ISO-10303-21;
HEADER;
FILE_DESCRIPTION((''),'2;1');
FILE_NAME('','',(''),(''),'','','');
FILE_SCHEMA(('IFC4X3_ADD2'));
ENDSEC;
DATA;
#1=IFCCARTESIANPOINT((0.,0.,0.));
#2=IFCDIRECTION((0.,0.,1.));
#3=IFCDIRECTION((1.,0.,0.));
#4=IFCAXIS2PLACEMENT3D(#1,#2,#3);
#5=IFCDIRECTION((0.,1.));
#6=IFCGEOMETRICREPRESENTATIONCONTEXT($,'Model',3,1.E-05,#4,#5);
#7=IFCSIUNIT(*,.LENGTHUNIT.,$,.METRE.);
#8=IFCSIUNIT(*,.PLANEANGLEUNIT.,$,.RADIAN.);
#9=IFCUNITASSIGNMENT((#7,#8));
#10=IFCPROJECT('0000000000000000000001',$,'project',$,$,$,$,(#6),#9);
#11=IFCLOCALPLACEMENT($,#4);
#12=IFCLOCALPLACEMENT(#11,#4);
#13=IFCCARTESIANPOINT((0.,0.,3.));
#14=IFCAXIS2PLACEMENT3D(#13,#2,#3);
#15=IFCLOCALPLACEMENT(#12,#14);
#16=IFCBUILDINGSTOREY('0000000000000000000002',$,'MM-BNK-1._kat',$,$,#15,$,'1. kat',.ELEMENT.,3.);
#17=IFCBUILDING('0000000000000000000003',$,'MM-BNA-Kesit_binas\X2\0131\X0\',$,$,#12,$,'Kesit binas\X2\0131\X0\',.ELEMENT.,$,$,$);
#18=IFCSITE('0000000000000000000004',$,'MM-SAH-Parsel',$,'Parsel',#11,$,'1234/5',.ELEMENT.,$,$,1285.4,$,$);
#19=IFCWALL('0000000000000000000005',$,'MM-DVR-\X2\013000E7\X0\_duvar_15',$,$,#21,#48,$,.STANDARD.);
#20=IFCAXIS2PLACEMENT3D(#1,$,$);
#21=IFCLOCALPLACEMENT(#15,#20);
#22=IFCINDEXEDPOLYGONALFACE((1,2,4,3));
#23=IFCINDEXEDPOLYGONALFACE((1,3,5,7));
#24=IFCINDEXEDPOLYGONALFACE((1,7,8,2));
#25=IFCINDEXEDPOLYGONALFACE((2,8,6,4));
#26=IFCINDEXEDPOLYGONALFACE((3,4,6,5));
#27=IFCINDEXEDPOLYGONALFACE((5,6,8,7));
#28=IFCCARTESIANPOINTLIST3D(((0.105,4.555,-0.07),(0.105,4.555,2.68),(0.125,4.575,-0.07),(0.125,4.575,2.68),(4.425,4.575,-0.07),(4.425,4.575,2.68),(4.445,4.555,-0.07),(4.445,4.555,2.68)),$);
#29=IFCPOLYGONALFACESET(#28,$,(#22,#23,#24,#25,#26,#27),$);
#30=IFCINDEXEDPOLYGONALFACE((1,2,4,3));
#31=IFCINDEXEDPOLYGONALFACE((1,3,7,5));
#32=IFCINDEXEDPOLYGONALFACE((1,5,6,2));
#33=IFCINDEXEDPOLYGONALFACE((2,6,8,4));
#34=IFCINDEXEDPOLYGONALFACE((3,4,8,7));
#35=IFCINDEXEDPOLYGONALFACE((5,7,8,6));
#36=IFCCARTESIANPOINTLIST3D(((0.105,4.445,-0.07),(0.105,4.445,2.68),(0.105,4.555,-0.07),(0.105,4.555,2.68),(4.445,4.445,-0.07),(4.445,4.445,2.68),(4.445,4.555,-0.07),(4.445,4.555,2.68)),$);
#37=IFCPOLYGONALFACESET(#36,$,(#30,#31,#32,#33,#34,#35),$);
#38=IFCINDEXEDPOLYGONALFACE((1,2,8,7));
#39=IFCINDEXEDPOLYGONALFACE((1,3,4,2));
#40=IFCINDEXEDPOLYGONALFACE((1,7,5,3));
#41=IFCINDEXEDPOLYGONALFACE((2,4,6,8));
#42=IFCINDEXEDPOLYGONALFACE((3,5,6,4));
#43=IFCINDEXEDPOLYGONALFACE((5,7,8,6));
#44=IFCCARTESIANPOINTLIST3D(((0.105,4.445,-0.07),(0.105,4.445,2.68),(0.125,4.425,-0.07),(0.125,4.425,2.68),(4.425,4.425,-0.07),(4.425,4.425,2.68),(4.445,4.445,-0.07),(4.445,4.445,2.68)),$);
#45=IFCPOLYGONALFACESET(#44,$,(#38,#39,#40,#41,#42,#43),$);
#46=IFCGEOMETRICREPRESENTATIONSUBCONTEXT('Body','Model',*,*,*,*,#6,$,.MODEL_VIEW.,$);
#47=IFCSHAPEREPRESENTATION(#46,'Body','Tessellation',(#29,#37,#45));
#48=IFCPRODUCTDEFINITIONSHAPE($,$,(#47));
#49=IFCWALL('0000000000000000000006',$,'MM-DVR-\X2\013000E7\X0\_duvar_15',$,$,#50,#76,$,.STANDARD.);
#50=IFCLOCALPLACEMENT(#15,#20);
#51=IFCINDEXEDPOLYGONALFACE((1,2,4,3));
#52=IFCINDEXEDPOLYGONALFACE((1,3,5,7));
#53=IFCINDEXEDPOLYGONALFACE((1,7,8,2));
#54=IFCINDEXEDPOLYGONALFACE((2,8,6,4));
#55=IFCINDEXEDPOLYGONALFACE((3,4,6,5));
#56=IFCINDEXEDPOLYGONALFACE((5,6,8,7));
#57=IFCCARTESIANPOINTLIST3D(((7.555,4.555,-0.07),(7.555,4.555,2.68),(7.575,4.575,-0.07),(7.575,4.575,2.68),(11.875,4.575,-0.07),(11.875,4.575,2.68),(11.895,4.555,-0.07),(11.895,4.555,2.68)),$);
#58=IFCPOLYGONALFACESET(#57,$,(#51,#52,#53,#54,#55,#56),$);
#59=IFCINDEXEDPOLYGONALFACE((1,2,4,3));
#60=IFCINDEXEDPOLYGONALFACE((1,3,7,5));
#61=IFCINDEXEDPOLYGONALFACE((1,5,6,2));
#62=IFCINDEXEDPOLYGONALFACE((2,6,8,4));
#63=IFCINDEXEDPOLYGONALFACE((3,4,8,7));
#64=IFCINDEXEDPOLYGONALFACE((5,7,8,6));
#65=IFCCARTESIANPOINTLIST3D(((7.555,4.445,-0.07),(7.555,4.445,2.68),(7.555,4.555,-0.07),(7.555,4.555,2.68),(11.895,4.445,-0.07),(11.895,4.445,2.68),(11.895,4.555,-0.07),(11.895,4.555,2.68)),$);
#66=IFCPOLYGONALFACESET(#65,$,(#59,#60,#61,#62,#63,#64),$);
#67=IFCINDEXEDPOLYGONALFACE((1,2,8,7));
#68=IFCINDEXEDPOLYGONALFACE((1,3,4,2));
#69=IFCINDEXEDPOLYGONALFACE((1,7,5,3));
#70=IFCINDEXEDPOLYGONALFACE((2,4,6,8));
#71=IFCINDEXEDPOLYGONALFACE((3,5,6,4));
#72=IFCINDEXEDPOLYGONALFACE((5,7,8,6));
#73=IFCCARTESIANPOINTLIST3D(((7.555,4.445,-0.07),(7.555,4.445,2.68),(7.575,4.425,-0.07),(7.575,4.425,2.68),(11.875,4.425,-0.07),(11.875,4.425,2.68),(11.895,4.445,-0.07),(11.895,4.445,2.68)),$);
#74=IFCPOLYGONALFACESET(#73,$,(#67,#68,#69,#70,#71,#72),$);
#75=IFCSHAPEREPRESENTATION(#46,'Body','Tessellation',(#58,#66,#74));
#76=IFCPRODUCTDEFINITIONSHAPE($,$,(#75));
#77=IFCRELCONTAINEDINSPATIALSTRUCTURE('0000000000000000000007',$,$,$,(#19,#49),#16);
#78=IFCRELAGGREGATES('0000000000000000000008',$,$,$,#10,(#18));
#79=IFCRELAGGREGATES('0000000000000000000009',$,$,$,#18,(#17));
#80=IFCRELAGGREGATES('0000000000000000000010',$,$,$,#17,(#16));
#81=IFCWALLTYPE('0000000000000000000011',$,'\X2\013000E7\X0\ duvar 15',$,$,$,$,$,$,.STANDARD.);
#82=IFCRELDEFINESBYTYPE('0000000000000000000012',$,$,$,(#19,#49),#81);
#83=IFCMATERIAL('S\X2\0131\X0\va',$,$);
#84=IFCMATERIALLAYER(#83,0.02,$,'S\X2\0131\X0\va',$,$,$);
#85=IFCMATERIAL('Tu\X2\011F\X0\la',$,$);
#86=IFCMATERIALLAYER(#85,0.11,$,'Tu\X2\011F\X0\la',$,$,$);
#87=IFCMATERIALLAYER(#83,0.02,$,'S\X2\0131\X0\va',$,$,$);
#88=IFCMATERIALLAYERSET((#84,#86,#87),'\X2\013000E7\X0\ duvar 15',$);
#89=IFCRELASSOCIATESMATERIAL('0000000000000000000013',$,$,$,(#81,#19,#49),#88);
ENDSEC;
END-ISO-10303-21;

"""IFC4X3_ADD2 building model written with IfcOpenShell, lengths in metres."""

from ifc_helpers import new_model, si_unit, direction, frame, origin_with_axes, place, context, subcontext, project, spatial, polyline, outline, extrude, material, layer, layer_set, type_object, element, save


model = new_model("IFC4X3_ADD2")

# Units and contexts
model_context = context("Model", 3, precision=1e-05, world=origin_with_axes(), true_north=direction((0.0, 1.0)))
body_context = subcontext(model_context, "Body", "Model", "MODEL_VIEW")
ifc_project = project(units=[si_unit("LENGTHUNIT", "METRE"), si_unit("PLANEANGLEUNIT", "RADIAN")], contexts=[model_context])

# Site, building, storey
site_placement = place(None, origin_with_axes())
site = spatial("IfcSite", under=ifc_project, at=site_placement, Name="MM-SAH-Parsel", ObjectType="Parsel", LongName="1234/5", CompositionType="ELEMENT", RefElevation=1285.4)
building_placement = place(site_placement, origin_with_axes())
building = spatial("IfcBuilding", under=site, at=building_placement, Name="MM-BNA-Kesit_binası", LongName="Kesit binası", CompositionType="ELEMENT")
storey_placement = place(building_placement, frame((0.0, 0.0, 3.0), z_axis=(0.0, 0.0, 1.0), x_axis=(1.0, 0.0, 0.0)))
storey = spatial("IfcBuildingStorey", under=building, at=storey_placement, Name="MM-BNK-1._kat", LongName="1. kat", CompositionType="ELEMENT", Elevation=3.0)

# Shared definitions
ifc_material_1 = material(Name="Tuğla")

# Shared definitions
ifc_material_2 = material(Name="Sıva")
ifc_layer_1 = layer(ifc_material_2, 0.02, Name="Sıva")
ifc_layer_2 = layer(ifc_material_1, 0.11, Name="Tuğla")
ifc_layer_3 = layer(ifc_material_2, 0.02, Name="Sıva")
ifc_layer_set_1 = layer_set([ifc_layer_1, ifc_layer_2, ifc_layer_3], Name="İç duvar 15")
wall_type_1 = type_object("IfcWallType", Name="İç duvar 15", PredefinedType="STANDARD", material=ifc_layer_set_1)

# Walls
wall_1_placement = place(storey_placement, origin_with_axes())
element("IfcWall", 1, at=wall_1_placement, inside=storey, type_object=wall_type_1, material=ifc_layer_set_1, Name="MM-DVR-İç_duvar_15", PredefinedType="STANDARD", context=body_context, shape_type="SweptSolid", body=[
    extrude(outline(polyline([(0.125, 4.575), (4.425, 4.575), (4.445, 4.555), (0.105, 4.555), (0.125, 4.575)])), frame((0.0, 0.0, -0.07)), (0.0, 0.0, 1.0), 2.75),
    extrude(outline(polyline([(0.105, 4.555), (4.445, 4.555), (4.445, 4.445), (0.105, 4.445), (0.105, 4.555)])), frame((0.0, 0.0, -0.07)), (0.0, 0.0, 1.0), 2.75),
    extrude(outline(polyline([(0.105, 4.445), (4.445, 4.445), (4.425, 4.425), (0.125, 4.425), (0.105, 4.445)])), frame((0.0, 0.0, -0.07)), (0.0, 0.0, 1.0), 2.75),
])
wall_2_placement = place(storey_placement, origin_with_axes())
element("IfcWall", 2, at=wall_2_placement, inside=storey, type_object=wall_type_1, material=ifc_layer_set_1, Name="MM-DVR-İç_duvar_15", PredefinedType="STANDARD", context=body_context, shape_type="SweptSolid", body=[
    extrude(outline(polyline([(7.575, 4.575), (11.875, 4.575), (11.895, 4.555), (7.555, 4.555), (7.575, 4.575)])), frame((0.0, 0.0, -0.07)), (0.0, 0.0, 1.0), 2.75),
    extrude(outline(polyline([(7.555, 4.555), (11.895, 4.555), (11.895, 4.445), (7.555, 4.445), (7.555, 4.555)])), frame((0.0, 0.0, -0.07)), (0.0, 0.0, 1.0), 2.75),
    extrude(outline(polyline([(7.555, 4.445), (11.895, 4.445), (11.875, 4.425), (7.575, 4.425), (7.555, 4.445)])), frame((0.0, 0.0, -0.07)), (0.0, 0.0, 1.0), 2.75),
])

save(model, "model.ifc")
